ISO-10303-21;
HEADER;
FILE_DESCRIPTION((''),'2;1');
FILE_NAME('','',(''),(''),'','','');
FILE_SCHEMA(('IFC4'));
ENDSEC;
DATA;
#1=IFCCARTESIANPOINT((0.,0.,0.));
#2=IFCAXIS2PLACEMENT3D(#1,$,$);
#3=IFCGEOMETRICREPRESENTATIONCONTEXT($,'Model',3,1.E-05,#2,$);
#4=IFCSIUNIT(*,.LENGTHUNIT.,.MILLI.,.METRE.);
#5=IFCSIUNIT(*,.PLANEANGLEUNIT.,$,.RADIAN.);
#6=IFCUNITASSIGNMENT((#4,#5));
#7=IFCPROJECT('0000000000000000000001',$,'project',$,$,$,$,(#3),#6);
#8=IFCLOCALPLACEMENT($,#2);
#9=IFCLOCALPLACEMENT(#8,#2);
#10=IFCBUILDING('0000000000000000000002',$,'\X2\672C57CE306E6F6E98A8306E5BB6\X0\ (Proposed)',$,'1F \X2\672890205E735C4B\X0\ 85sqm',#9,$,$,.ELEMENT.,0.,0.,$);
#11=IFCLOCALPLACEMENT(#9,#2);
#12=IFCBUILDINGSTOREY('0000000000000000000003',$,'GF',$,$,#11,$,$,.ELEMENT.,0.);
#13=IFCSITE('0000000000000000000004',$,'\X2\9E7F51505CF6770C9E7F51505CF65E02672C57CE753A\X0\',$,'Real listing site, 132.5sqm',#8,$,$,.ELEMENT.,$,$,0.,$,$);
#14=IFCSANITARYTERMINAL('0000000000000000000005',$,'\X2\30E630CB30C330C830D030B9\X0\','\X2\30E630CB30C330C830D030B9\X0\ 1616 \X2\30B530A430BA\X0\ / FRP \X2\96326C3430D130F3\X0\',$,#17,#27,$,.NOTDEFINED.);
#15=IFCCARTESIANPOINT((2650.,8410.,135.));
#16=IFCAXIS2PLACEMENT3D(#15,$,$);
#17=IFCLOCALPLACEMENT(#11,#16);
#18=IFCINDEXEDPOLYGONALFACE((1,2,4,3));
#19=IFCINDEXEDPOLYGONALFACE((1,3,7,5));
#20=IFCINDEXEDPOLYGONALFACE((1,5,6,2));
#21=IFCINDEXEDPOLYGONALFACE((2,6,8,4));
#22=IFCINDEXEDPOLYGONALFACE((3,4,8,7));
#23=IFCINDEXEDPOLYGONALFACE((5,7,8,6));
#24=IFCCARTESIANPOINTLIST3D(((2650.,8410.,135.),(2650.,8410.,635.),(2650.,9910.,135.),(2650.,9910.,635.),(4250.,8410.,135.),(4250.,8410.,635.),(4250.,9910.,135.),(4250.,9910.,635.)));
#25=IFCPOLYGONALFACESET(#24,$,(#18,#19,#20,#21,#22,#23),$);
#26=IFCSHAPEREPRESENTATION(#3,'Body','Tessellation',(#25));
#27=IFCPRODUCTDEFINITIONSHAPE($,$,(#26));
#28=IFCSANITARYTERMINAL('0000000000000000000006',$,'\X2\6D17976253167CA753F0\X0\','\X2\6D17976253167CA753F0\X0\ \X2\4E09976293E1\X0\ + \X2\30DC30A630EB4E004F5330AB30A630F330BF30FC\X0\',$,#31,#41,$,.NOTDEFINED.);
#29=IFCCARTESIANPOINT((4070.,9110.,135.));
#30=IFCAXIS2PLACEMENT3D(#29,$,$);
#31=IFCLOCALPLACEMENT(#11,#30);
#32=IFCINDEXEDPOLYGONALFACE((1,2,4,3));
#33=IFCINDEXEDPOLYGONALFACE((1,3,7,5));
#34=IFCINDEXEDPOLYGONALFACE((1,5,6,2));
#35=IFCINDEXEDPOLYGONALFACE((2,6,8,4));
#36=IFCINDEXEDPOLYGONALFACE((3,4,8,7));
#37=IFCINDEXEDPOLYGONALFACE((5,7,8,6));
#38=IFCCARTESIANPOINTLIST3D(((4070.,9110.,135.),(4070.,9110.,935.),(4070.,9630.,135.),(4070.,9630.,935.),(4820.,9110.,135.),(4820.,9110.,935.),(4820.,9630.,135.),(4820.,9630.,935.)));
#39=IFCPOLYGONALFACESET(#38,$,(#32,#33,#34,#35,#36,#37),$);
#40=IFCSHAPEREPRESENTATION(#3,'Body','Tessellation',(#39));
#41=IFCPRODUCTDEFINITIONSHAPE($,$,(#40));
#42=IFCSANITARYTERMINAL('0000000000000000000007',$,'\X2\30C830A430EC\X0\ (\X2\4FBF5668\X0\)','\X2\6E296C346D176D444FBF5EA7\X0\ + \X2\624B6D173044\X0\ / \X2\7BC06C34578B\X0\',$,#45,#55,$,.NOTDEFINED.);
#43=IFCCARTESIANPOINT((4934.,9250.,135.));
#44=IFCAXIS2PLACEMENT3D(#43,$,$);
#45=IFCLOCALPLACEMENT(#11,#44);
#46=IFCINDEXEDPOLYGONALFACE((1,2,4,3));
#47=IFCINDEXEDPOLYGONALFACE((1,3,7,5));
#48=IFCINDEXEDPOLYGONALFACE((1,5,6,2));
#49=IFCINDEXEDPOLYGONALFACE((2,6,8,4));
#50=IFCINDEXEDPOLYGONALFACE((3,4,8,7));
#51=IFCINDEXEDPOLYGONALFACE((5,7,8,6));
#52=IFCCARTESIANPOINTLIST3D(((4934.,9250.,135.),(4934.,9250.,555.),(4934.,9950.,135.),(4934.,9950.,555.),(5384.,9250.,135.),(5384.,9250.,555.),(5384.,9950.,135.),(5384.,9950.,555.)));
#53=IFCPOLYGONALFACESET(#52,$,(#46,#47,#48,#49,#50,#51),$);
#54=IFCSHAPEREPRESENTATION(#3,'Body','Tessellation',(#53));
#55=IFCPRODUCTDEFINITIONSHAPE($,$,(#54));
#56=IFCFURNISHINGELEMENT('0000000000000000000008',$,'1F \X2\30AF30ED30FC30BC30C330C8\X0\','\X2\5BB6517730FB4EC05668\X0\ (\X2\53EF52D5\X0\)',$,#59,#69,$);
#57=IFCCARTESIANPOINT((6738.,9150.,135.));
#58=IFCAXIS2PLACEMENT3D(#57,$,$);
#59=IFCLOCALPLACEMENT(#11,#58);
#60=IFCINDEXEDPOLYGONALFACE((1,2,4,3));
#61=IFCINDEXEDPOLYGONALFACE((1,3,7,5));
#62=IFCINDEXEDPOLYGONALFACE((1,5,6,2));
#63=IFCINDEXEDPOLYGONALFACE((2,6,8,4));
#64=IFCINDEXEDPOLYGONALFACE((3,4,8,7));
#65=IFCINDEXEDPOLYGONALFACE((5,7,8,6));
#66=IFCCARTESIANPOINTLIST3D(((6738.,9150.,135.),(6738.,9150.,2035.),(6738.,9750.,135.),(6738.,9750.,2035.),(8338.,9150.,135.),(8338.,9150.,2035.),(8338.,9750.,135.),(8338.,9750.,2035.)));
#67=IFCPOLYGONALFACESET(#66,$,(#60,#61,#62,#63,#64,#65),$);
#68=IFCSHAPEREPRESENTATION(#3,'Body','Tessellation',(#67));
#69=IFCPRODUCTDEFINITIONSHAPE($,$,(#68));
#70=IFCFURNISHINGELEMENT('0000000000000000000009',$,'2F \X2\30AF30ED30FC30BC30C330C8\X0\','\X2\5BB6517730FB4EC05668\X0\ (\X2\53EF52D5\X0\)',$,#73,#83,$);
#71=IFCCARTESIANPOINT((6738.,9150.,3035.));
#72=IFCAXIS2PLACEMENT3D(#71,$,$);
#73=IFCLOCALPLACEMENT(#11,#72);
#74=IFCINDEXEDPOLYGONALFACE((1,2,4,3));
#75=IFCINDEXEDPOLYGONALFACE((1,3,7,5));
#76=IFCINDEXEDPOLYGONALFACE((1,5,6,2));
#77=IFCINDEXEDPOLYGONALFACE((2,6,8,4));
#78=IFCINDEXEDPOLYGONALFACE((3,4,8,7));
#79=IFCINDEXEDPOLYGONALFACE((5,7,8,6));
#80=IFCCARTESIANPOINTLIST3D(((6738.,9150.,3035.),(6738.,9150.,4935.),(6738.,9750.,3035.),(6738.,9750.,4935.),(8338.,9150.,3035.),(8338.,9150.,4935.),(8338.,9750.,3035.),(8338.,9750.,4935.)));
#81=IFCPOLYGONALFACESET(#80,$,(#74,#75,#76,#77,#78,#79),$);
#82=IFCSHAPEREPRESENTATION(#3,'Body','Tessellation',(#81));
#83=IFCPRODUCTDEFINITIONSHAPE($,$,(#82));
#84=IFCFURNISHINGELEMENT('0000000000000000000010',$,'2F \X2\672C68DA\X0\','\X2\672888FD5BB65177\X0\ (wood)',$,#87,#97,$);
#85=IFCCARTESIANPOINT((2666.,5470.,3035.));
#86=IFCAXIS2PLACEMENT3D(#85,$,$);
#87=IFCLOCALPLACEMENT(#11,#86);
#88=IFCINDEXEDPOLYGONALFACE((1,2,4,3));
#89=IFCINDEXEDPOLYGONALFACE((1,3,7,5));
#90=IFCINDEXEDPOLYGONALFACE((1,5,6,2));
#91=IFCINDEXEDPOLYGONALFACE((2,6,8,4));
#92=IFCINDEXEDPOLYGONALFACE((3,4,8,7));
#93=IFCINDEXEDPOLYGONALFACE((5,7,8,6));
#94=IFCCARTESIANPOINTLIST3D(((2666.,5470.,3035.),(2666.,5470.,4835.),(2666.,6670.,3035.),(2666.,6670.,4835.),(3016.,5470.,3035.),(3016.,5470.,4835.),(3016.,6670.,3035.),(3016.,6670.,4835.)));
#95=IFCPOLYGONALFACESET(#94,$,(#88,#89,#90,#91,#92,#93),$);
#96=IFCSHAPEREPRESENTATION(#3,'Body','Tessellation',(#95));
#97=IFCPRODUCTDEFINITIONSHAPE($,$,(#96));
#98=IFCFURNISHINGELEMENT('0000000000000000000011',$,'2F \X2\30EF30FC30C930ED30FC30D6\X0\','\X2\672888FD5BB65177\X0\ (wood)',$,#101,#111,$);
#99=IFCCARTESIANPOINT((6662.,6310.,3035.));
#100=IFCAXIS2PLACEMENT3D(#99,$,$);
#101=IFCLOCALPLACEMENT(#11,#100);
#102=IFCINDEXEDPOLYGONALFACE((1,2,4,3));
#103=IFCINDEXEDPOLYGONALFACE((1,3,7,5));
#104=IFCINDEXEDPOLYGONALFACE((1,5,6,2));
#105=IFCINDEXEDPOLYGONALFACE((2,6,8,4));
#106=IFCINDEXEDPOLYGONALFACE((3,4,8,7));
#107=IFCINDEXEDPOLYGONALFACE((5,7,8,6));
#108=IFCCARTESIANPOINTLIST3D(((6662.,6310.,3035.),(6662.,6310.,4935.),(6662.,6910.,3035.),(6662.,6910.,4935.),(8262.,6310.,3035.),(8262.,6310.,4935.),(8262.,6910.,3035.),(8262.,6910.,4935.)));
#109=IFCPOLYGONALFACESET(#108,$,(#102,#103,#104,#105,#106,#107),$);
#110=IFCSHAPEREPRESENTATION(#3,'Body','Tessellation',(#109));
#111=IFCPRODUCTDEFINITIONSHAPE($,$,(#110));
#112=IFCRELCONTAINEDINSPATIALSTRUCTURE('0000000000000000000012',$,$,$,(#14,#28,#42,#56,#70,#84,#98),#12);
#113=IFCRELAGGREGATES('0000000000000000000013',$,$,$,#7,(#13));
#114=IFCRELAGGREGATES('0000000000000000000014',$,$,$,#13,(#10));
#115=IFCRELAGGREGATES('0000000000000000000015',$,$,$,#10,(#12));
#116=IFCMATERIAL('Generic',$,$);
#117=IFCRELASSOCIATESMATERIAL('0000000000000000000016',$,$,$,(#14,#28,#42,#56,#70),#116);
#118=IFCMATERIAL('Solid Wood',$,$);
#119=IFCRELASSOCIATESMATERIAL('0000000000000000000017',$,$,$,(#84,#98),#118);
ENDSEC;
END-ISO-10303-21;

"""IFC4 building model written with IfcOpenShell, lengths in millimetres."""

from ifc_helpers import new_model, si_unit, frame, frame_2d, origin, place, context, project, spatial, rectangle, extrude, material, element, save


model = new_model("IFC4")

# Units and contexts
model_context = context("Model", 3, precision=1e-05, world=origin())
ifc_project = project(units=[si_unit("LENGTHUNIT", "METRE", prefix="MILLI"), si_unit("PLANEANGLEUNIT", "RADIAN")], contexts=[model_context])

# Site, building, storey
site_placement = place(None, origin())
site = spatial("IfcSite", under=ifc_project, at=site_placement, Name="鹿児島県鹿児島市本城町", ObjectType="Real listing site, 132.5sqm", CompositionType="ELEMENT", RefElevation=0.0)
building_placement = place(site_placement, origin())
building = spatial("IfcBuilding", under=site, at=building_placement, Name="本城の潮風の家 (Proposed)", ObjectType="1F 木造平屋 85sqm", CompositionType="ELEMENT", ElevationOfRefHeight=0.0, ElevationOfTerrain=0.0)
storey_placement = place(building_placement, origin())
storey = spatial("IfcBuildingStorey", under=building, at=storey_placement, Name="GF", CompositionType="ELEMENT", Elevation=0.0)

# Shared definitions
ifc_material_1 = material(Name="Solid Wood")

# Shared definitions
ifc_material_2 = material(Name="Generic")

# Sanitary terminals
sanitary_terminal_1_placement = place(storey_placement, frame((2650.0, 8410.0, 135.0)))
element("IfcSanitaryTerminal", 1, at=sanitary_terminal_1_placement, inside=storey, material=ifc_material_2, Name="ユニットバス", Description="ユニットバス 1616 サイズ / FRP 防水パン", PredefinedType="NOTDEFINED", context=model_context, shape_type="SweptSolid", body=[
    extrude(rectangle(XDim=1600.0, YDim=1500.0, at=frame_2d((800.0, 750.0))), frame((2650.0, 8410.0, 135.0)), (0.0, 0.0, 1.0), 500.0),
])
sanitary_terminal_2_placement = place(storey_placement, frame((4070.0, 9110.0, 135.0)))
element("IfcSanitaryTerminal", 2, at=sanitary_terminal_2_placement, inside=storey, material=ifc_material_2, Name="洗面化粧台", Description="洗面化粧台 三面鏡 + ボウル一体カウンター", PredefinedType="NOTDEFINED", context=model_context, shape_type="SweptSolid", body=[
    extrude(rectangle(XDim=750.0, YDim=520.0, at=frame_2d((375.0, 260.0))), frame((4070.0, 9110.0, 135.0)), (0.0, 0.0, 1.0), 800.0),
])
sanitary_terminal_3_placement = place(storey_placement, frame((4934.0, 9250.0, 135.0)))
element("IfcSanitaryTerminal", 3, at=sanitary_terminal_3_placement, inside=storey, material=ifc_material_2, Name="トイレ (便器)", Description="温水洗浄便座 + 手洗い / 節水型", PredefinedType="NOTDEFINED", context=model_context, shape_type="SweptSolid", body=[
    extrude(rectangle(XDim=450.0, YDim=700.0, at=frame_2d((225.0, 350.0))), frame((4934.0, 9250.0, 135.0)), (0.0, 0.0, 1.0), 420.0),
])

# Furnishing elements
furnishing_1_placement = place(storey_placement, frame((6738.0, 9150.0, 135.0)))
element("IfcFurnishingElement", 4, at=furnishing_1_placement, inside=storey, material=ifc_material_2, Name="1F クローゼット", Description="家具・什器 (可動)", context=model_context, shape_type="SweptSolid", body=[
    extrude(rectangle(XDim=1600.0, YDim=600.0, at=frame_2d((800.0, 300.0))), frame((6738.0, 9150.0, 135.0)), (0.0, 0.0, 1.0), 1900.0),
])
furnishing_2_placement = place(storey_placement, frame((6738.0, 9150.0, 3035.0)))
element("IfcFurnishingElement", 5, at=furnishing_2_placement, inside=storey, material=ifc_material_2, Name="2F クローゼット", Description="家具・什器 (可動)", context=model_context, shape_type="SweptSolid", body=[
    extrude(rectangle(XDim=1600.0, YDim=600.0, at=frame_2d((800.0, 300.0))), frame((6738.0, 9150.0, 3035.0)), (0.0, 0.0, 1.0), 1900.0),
])
furnishing_3_placement = place(storey_placement, frame((2666.0, 5470.0, 3035.0)))
element("IfcFurnishingElement", 6, at=furnishing_3_placement, inside=storey, material=ifc_material_1, Name="2F 本棚", Description="木製家具 (wood)", context=model_context, shape_type="SweptSolid", body=[
    extrude(rectangle(XDim=350.0, YDim=1200.0, at=frame_2d((175.0, 600.0))), frame((2666.0, 5470.0, 3035.0)), (0.0, 0.0, 1.0), 1800.0),
])
furnishing_4_placement = place(storey_placement, frame((6662.0, 6310.0, 3035.0)))
element("IfcFurnishingElement", 7, at=furnishing_4_placement, inside=storey, material=ifc_material_1, Name="2F ワードローブ", Description="木製家具 (wood)", context=model_context, shape_type="SweptSolid", body=[
    extrude(rectangle(XDim=1600.0, YDim=600.0, at=frame_2d((800.0, 300.0))), frame((6662.0, 6310.0, 3035.0)), (0.0, 0.0, 1.0), 1900.0),
])

save(model, "model.ifc")
